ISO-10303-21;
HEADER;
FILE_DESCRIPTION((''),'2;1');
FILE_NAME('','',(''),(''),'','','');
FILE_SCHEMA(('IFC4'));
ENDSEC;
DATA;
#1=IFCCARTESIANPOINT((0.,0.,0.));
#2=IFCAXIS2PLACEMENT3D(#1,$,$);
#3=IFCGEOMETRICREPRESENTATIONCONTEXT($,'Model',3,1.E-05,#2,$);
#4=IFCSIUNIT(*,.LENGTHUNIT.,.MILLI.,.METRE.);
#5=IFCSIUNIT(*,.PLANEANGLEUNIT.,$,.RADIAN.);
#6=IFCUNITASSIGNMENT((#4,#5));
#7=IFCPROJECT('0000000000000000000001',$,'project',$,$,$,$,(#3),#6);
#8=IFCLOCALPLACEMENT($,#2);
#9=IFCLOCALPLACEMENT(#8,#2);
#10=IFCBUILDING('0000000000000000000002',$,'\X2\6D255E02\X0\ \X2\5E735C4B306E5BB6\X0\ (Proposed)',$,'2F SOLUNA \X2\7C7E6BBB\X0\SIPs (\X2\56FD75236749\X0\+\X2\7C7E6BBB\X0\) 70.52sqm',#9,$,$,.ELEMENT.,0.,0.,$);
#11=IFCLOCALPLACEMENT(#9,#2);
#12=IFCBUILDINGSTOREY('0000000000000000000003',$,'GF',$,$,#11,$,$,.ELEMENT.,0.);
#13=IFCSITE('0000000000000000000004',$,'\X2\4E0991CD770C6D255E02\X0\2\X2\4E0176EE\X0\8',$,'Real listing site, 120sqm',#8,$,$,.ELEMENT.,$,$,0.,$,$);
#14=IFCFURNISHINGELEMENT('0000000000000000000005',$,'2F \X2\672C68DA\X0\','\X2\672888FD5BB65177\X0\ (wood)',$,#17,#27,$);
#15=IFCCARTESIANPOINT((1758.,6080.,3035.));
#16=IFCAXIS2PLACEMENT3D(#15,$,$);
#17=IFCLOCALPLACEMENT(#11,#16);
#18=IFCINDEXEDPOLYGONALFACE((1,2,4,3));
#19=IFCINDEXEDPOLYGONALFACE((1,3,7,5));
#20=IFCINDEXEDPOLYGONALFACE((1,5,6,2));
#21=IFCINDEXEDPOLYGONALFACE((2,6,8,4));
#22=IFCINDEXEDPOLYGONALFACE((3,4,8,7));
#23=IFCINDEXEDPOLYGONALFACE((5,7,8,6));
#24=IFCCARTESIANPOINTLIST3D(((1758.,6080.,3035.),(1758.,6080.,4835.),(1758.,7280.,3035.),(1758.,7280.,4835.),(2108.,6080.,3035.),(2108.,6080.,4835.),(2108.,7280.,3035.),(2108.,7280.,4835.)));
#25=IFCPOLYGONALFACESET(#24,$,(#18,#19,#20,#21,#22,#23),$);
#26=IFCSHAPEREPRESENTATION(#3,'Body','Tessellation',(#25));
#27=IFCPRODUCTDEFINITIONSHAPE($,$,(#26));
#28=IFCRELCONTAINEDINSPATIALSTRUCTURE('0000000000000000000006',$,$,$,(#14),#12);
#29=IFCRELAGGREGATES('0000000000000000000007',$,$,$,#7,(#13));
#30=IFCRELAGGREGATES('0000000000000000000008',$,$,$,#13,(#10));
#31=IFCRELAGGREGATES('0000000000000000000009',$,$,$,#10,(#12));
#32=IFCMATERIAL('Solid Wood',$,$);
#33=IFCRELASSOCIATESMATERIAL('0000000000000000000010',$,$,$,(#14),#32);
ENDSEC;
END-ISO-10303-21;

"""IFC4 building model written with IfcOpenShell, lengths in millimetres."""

from ifc_helpers import new_model, si_unit, frame, frame_2d, origin, place, context, project, spatial, rectangle, extrude, material, element, save


model = new_model("IFC4")

# Units and contexts
model_context = context("Model", 3, precision=1e-05, world=origin())
ifc_project = project(units=[si_unit("LENGTHUNIT", "METRE", prefix="MILLI"), si_unit("PLANEANGLEUNIT", "RADIAN")], contexts=[model_context])

# Site, building, storey
site_placement = place(None, origin())
site = spatial("IfcSite", under=ifc_project, at=site_placement, Name="三重県津市2丁目8", ObjectType="Real listing site, 120sqm", CompositionType="ELEMENT", RefElevation=0.0)
building_placement = place(site_placement, origin())
building = spatial("IfcBuilding", under=site, at=building_placement, Name="津市 平屋の家 (Proposed)", ObjectType="2F SOLUNA 籾殻SIPs (国産杉+籾殻) 70.52sqm", CompositionType="ELEMENT", ElevationOfRefHeight=0.0, ElevationOfTerrain=0.0)
storey_placement = place(building_placement, origin())
storey = spatial("IfcBuildingStorey", under=building, at=storey_placement, Name="GF", CompositionType="ELEMENT", Elevation=0.0)

# Shared definitions
ifc_material_1 = material(Name="Solid Wood")

# Furnishing element
furnishing_placement = place(storey_placement, frame((1758.0, 6080.0, 3035.0)))
element("IfcFurnishingElement", 1, at=furnishing_placement, inside=storey, material=ifc_material_1, Name="2F 本棚", Description="木製家具 (wood)", context=model_context, shape_type="SweptSolid", body=[
    extrude(rectangle(XDim=350.0, YDim=1200.0, at=frame_2d((175.0, 600.0))), frame((1758.0, 6080.0, 3035.0)), (0.0, 0.0, 1.0), 1800.0),
])

save(model, "model.ifc")
